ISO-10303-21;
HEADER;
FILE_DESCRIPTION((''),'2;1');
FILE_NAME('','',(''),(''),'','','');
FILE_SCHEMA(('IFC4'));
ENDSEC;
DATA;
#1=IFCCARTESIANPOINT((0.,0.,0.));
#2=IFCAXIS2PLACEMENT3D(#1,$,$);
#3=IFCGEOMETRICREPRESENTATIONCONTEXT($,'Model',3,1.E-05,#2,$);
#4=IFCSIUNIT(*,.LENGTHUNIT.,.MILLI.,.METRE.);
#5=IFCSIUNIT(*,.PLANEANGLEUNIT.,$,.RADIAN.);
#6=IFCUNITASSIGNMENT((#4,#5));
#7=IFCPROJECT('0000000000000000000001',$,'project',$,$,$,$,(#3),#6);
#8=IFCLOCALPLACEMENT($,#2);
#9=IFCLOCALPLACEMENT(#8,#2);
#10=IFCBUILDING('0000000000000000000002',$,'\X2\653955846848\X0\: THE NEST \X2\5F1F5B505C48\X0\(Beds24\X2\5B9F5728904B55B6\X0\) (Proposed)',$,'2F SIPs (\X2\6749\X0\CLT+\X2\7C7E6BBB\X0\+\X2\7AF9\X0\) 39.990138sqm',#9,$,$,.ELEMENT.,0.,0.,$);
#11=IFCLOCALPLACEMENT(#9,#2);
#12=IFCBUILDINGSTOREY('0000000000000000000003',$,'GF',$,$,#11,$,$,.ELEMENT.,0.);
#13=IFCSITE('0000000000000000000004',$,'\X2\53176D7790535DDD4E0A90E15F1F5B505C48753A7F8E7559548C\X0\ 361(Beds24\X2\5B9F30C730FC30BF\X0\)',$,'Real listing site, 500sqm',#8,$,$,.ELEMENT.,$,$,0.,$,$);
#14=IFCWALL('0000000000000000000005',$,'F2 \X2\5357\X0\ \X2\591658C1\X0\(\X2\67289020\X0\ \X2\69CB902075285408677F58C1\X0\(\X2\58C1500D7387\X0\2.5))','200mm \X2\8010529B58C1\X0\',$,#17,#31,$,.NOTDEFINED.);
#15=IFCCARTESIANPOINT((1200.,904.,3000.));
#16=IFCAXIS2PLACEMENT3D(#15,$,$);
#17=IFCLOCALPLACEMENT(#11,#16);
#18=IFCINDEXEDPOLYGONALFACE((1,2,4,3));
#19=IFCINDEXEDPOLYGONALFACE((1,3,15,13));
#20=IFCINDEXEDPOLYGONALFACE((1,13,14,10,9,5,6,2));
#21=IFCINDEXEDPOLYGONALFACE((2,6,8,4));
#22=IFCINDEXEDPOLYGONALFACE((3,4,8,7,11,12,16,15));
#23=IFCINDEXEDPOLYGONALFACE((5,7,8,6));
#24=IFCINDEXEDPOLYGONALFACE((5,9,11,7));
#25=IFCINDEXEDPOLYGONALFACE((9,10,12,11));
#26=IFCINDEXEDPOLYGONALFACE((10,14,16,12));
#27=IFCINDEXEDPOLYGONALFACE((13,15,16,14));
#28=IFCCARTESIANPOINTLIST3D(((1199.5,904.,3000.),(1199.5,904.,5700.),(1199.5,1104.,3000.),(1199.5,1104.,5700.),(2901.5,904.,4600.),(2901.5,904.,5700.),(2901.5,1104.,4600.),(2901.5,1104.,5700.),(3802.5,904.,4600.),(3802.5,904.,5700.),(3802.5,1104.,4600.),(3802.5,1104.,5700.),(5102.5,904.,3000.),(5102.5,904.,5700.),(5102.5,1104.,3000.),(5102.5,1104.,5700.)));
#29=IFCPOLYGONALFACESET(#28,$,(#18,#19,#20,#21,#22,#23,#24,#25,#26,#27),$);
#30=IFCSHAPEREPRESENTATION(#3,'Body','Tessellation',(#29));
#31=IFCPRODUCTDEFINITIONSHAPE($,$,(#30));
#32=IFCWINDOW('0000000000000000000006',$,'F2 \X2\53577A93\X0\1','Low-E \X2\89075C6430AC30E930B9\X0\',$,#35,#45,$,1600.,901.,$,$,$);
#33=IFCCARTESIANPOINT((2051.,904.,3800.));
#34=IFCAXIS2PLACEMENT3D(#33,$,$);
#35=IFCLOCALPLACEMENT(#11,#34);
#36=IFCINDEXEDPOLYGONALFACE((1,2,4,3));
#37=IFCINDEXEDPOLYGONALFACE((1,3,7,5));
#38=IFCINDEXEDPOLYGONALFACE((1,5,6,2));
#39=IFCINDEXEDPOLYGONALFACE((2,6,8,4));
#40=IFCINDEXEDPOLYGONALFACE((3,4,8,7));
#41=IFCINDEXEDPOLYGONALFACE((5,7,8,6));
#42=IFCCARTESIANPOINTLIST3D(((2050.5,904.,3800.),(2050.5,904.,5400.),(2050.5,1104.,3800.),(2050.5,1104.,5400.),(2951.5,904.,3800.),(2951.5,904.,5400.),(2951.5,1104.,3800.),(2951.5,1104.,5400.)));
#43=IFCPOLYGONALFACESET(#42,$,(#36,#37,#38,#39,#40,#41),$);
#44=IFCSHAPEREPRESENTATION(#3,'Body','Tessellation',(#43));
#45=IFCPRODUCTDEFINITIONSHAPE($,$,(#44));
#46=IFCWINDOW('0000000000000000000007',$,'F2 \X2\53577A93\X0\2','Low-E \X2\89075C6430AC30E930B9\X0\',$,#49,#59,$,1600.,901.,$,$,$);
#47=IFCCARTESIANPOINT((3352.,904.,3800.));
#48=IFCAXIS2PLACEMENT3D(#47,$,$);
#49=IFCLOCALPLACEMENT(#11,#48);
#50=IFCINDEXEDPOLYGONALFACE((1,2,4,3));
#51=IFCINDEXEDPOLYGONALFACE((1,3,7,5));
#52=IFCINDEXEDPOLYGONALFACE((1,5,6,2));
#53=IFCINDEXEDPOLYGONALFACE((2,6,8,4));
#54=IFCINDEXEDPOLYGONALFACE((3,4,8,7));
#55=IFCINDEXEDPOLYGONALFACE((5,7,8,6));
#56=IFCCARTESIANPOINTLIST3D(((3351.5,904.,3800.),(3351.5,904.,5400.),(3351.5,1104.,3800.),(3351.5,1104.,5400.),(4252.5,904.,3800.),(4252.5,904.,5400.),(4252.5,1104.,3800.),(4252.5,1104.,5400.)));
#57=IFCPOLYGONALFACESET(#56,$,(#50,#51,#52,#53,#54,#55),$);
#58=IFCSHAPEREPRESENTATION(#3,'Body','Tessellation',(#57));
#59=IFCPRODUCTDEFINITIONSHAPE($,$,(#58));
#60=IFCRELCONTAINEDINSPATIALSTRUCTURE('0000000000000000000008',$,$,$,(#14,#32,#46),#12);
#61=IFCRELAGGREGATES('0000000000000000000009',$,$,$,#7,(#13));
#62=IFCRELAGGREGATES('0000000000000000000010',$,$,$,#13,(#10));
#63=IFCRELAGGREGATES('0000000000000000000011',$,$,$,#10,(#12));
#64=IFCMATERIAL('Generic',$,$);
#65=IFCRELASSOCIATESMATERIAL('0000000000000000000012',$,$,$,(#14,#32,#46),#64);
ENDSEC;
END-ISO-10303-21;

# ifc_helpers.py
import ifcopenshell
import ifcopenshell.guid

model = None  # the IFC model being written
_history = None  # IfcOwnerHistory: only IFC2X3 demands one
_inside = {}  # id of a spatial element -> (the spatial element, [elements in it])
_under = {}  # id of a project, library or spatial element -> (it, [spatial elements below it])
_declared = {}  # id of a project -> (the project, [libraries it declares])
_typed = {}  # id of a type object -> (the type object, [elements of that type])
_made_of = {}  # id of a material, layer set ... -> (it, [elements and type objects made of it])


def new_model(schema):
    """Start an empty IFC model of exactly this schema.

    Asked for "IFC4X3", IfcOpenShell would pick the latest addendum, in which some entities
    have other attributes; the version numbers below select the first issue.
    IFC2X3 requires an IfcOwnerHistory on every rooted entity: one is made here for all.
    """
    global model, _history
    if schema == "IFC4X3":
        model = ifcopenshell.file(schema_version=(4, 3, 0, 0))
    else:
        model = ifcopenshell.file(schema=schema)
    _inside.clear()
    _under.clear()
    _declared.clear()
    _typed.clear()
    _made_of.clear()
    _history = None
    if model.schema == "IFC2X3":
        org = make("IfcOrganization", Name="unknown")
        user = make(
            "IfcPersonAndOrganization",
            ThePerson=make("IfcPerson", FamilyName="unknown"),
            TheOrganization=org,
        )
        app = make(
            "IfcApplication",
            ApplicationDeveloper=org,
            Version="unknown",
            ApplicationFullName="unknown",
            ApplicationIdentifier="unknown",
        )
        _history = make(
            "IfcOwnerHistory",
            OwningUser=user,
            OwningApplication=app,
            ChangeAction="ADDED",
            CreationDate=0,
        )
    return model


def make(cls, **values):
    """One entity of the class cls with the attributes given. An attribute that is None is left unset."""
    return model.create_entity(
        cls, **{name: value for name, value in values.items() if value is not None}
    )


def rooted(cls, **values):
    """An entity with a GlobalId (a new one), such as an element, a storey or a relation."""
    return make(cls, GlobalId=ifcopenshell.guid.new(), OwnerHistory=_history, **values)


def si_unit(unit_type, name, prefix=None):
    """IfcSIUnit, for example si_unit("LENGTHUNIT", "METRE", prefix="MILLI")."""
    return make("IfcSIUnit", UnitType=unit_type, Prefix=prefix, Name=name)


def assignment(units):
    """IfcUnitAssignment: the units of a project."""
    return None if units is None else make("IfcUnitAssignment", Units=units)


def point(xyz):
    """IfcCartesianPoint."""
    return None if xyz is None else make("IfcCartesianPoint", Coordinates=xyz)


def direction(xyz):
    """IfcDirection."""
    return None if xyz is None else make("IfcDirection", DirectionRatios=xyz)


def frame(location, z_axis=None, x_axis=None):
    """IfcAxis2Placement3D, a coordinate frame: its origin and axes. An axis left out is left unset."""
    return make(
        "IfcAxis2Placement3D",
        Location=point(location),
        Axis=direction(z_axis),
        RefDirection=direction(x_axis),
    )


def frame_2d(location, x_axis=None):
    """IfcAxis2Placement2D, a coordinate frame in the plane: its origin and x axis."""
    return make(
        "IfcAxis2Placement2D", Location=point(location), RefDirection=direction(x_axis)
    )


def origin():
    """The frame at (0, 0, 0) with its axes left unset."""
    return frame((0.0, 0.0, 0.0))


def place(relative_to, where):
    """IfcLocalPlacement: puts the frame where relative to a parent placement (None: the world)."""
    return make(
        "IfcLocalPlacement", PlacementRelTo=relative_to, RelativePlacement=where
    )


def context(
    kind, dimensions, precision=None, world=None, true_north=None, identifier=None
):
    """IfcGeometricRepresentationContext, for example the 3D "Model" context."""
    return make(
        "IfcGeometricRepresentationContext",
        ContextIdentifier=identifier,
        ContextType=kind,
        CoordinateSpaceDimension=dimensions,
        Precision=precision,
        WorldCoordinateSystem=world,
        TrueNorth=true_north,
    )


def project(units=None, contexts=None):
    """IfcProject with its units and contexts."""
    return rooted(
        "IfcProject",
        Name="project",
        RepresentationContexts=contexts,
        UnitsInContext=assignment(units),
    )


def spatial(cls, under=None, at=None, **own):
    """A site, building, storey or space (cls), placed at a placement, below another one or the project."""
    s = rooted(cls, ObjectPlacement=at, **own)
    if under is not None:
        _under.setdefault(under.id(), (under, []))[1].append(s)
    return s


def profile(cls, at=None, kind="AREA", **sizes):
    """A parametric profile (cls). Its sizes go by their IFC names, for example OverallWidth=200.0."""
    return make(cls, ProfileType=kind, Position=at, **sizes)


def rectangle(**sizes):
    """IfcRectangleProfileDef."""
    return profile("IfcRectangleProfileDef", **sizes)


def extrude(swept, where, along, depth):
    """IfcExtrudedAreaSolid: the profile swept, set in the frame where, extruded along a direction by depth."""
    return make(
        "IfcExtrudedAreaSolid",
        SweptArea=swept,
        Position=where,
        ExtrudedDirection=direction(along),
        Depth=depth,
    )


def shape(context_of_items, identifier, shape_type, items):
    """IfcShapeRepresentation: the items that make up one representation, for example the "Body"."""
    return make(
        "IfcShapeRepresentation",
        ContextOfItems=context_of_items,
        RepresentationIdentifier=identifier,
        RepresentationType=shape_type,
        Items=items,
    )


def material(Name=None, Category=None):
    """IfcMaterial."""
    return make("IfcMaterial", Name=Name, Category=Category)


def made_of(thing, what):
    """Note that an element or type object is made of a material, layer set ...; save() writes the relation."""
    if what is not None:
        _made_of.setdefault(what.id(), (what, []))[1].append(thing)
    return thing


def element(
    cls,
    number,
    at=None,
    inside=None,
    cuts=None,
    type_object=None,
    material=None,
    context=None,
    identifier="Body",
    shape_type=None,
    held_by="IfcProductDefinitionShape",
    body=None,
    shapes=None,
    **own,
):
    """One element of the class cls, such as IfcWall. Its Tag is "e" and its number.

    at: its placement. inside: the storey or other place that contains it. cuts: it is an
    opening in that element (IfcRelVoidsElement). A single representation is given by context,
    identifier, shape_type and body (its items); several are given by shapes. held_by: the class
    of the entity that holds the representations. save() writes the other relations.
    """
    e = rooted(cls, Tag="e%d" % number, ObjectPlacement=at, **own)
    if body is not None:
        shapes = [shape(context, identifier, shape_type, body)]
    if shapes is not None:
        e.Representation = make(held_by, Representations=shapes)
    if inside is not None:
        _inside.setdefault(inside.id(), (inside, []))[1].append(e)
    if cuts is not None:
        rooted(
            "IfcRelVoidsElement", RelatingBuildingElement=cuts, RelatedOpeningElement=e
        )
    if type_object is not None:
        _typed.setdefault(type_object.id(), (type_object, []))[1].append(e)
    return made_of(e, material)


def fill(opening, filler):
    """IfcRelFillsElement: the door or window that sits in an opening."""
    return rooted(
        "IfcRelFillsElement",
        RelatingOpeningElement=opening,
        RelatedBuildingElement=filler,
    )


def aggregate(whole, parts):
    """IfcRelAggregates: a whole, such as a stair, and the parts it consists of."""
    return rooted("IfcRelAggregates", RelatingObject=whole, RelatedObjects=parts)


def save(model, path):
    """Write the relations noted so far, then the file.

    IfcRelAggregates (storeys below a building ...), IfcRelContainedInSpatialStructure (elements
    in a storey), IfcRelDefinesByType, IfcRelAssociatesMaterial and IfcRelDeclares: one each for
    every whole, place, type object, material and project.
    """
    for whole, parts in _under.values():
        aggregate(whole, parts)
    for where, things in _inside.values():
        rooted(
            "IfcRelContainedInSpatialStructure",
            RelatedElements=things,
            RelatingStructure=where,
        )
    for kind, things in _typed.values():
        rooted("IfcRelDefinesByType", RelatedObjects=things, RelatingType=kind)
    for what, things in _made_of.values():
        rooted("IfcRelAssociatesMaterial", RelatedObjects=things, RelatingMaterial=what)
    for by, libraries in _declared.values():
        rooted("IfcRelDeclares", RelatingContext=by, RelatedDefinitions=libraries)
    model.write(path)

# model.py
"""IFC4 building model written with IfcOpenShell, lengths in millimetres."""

from ifc_helpers import new_model, si_unit, frame, frame_2d, origin, place, context, project, spatial, rectangle, extrude, material, element, fill, save


model = new_model("IFC4")

# Units and contexts
model_context = context("Model", 3, precision=1e-05, world=origin())
ifc_project = project(units=[si_unit("LENGTHUNIT", "METRE", prefix="MILLI"), si_unit("PLANEANGLEUNIT", "RADIAN")], contexts=[model_context])

# Site, building, storey
site_placement = place(None, origin())
site = spatial("IfcSite", under=ifc_project, at=site_placement, Name="北海道川上郡弟子屈町美留和 361(Beds24実データ)", ObjectType="Real listing site, 500sqm", CompositionType="ELEMENT", RefElevation=0.0)
building_placement = place(site_placement, origin())
building = spatial("IfcBuilding", under=site, at=building_placement, Name="改善案: THE NEST 弟子屈(Beds24実在運営) (Proposed)", ObjectType="2F SIPs (杉CLT+籾殻+竹) 39.990138sqm", CompositionType="ELEMENT", ElevationOfRefHeight=0.0, ElevationOfTerrain=0.0)
storey_placement = place(building_placement, origin())
storey = spatial("IfcBuildingStorey", under=building, at=storey_placement, Name="GF", CompositionType="ELEMENT", Elevation=0.0)

# Shared definitions
ifc_material_1 = material(Name="Generic")

# Wall, openings, windows
wall_1_placement = place(storey_placement, frame((1200.0, 904.0, 3000.0)))
wall_1 = element("IfcWall", 1, at=wall_1_placement, inside=storey, material=ifc_material_1, Name="F2 南 外壁(木造 構造用合板壁(壁倍率2.5))", Description="200mm 耐力壁", PredefinedType="NOTDEFINED", context=model_context, shape_type="SweptSolid", body=[
    extrude(rectangle(XDim=3903.0, YDim=200.0, at=frame_2d((1951.0, 100.0))), frame((1200.0, 904.0, 3000.0)), (0.0, 0.0, 1.0), 2700.0),
])
opening_1_placement = place(storey_placement, frame((2051.0, 904.0, 3800.0)))
opening_1 = element("IfcOpeningElement", 2, at=opening_1_placement, cuts=wall_1, PredefinedType="NOTDEFINED", context=model_context, shape_type="SweptSolid", body=[
    extrude(rectangle(XDim=901.0, YDim=200.0, at=frame_2d((450.0, 100.0))), frame((2051.0, 904.0, 3800.0)), (0.0, 0.0, 1.0), 1600.0),
])
opening_2_placement = place(storey_placement, frame((3352.0, 904.0, 3800.0)))
opening_2 = element("IfcOpeningElement", 3, at=opening_2_placement, cuts=wall_1, PredefinedType="NOTDEFINED", context=model_context, shape_type="SweptSolid", body=[
    extrude(rectangle(XDim=901.0, YDim=200.0, at=frame_2d((450.0, 100.0))), frame((3352.0, 904.0, 3800.0)), (0.0, 0.0, 1.0), 1600.0),
])
window_1_placement = place(storey_placement, frame((2051.0, 904.0, 3800.0)))
window_1 = element("IfcWindow", 4, at=window_1_placement, inside=storey, material=ifc_material_1, Name="F2 南窓1", Description="Low-E 複層ガラス", OverallHeight=1600.0, OverallWidth=901.0, context=model_context, shape_type="SweptSolid", body=[
    extrude(rectangle(XDim=901.0, YDim=200.0, at=frame_2d((450.0, 100.0))), frame((2051.0, 904.0, 3800.0)), (0.0, 0.0, 1.0), 1600.0),
])
fill(opening_1, window_1)
window_2_placement = place(storey_placement, frame((3352.0, 904.0, 3800.0)))
window_2 = element("IfcWindow", 5, at=window_2_placement, inside=storey, material=ifc_material_1, Name="F2 南窓2", Description="Low-E 複層ガラス", OverallHeight=1600.0, OverallWidth=901.0, context=model_context, shape_type="SweptSolid", body=[
    extrude(rectangle(XDim=901.0, YDim=200.0, at=frame_2d((450.0, 100.0))), frame((3352.0, 904.0, 3800.0)), (0.0, 0.0, 1.0), 1600.0),
])
fill(opening_2, window_2)

save(model, "model.ifc")
